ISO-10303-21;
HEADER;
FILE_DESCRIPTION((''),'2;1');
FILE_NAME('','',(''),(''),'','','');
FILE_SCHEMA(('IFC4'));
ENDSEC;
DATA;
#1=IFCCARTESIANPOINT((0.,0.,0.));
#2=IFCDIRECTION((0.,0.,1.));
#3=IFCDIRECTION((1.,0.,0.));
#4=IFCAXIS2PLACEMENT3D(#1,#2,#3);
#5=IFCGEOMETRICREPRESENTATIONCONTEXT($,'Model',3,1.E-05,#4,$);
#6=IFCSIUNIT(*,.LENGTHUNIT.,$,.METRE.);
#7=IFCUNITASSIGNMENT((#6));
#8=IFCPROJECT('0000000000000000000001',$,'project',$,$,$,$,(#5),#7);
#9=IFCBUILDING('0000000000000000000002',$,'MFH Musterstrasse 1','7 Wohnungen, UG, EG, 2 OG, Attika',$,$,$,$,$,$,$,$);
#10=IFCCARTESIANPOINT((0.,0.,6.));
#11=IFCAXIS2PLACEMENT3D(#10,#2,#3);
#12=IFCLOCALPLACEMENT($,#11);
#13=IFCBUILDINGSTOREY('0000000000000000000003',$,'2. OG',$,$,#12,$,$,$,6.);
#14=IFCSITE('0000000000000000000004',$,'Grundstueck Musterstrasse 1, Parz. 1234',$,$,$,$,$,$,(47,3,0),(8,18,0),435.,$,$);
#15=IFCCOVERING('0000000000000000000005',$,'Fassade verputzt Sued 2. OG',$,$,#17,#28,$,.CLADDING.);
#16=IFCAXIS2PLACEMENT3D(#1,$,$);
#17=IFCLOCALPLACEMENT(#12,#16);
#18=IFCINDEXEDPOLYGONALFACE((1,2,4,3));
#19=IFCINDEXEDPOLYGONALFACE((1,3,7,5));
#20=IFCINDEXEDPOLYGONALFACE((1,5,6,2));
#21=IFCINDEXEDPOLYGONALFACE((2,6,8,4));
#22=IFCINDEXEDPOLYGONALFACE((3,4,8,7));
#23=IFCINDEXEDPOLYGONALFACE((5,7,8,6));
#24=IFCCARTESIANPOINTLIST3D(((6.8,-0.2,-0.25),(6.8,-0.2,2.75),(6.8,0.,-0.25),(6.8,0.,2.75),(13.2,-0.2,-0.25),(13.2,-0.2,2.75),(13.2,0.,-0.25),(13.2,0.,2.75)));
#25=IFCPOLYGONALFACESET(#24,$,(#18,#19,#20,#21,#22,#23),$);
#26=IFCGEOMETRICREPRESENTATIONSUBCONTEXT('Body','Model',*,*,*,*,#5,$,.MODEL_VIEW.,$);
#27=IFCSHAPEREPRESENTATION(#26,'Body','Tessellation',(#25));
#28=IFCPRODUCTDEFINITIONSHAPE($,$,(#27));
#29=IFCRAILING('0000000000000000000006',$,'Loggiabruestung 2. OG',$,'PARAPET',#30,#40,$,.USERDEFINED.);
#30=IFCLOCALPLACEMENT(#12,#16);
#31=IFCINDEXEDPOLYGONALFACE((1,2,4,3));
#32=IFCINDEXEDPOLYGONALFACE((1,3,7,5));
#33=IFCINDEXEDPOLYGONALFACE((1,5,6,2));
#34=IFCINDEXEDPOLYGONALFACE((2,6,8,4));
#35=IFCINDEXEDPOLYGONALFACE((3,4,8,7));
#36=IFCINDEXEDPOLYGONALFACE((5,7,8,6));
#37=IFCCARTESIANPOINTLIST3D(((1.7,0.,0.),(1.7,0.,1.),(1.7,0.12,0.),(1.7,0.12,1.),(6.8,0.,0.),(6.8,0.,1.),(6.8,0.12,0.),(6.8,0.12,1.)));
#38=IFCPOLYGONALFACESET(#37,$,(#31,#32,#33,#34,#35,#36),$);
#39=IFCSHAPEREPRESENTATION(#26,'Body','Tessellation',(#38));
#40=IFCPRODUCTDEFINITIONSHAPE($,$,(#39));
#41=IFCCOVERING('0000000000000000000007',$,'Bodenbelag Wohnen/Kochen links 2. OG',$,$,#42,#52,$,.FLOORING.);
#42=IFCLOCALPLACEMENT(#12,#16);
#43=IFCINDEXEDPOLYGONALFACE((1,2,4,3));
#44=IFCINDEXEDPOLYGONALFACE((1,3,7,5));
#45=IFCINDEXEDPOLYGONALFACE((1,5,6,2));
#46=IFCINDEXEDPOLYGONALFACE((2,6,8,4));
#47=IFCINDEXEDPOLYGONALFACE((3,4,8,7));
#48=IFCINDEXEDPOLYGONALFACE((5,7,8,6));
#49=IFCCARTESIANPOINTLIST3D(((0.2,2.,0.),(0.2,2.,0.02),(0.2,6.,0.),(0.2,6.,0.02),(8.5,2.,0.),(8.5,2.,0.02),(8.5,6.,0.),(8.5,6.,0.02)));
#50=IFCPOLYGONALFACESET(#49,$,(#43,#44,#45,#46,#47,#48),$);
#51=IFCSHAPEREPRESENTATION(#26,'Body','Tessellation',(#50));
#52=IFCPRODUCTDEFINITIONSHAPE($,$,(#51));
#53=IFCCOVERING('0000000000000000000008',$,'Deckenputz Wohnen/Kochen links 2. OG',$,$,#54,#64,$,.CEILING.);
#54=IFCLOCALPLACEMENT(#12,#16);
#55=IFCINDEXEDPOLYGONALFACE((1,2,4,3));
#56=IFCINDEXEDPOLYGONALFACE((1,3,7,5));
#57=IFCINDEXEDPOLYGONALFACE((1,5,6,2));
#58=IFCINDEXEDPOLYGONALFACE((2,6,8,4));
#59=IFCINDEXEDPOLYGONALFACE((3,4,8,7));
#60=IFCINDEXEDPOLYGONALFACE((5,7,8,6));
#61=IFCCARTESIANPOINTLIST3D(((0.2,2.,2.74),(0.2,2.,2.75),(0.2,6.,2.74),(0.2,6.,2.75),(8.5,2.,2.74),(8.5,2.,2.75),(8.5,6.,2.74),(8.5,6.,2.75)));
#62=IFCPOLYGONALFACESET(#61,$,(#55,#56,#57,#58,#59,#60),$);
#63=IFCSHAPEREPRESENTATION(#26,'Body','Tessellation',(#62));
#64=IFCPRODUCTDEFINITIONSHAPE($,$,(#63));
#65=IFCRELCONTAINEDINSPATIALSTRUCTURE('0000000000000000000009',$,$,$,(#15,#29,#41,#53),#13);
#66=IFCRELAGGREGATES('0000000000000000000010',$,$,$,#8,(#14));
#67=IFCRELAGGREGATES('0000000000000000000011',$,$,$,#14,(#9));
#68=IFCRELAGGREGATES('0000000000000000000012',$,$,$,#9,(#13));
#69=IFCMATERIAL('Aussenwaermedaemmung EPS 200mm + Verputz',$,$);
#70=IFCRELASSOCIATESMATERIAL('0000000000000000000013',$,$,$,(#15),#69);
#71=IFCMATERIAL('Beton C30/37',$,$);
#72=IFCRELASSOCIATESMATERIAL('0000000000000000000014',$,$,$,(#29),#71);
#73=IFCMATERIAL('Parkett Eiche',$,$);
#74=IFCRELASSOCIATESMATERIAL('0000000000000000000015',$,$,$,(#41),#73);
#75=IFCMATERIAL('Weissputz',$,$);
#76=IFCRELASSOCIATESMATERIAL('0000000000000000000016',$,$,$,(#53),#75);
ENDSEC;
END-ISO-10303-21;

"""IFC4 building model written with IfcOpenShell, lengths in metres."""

from ifc_helpers import new_model, si_unit, frame, frame_2d, origin_with_axes, place, context, subcontext, project, spatial, rectangle, extrude, material, element, save


model = new_model("IFC4")

# Units and contexts
model_context = context("Model", 3, precision=1e-05, world=origin_with_axes())
body_context = subcontext(model_context, "Body", "Model", "MODEL_VIEW")
ifc_project = project(units=[si_unit("LENGTHUNIT", "METRE")], contexts=[model_context])

# Site, building, storey
site = spatial("IfcSite", under=ifc_project, Name="Grundstueck Musterstrasse 1, Parz. 1234", RefLatitude=(47, 3, 0), RefLongitude=(8, 18, 0), RefElevation=435.0)
building = spatial("IfcBuilding", under=site, Name="MFH Musterstrasse 1", Description="7 Wohnungen, UG, EG, 2 OG, Attika")
storey_placement = place(None, frame((0.0, 0.0, 6.0), z_axis=(0.0, 0.0, 1.0), x_axis=(1.0, 0.0, 0.0)))
storey = spatial("IfcBuildingStorey", under=building, at=storey_placement, Name="2. OG", Elevation=6.0)

# Shared definitions
ifc_material_1 = material(Name="Aussenwaermedaemmung EPS 200mm + Verputz")

# Covering
covering_1_placement = place(storey_placement, frame((7.0, -0.2, -0.25), z_axis=(0.0, 0.0, 1.0), x_axis=(1.0, 0.0, 0.0)))
element("IfcCovering", 1, at=covering_1_placement, inside=storey, material=ifc_material_1, Name="Fassade verputzt Sued 2. OG", PredefinedType="CLADDING", context=body_context, shape_type="SweptSolid", body=[
    extrude(rectangle(XDim=6.4, YDim=0.2, at=frame_2d((3.0, 0.1))), origin_with_axes(), (0.0, 0.0, 1.0), 3.0),
])

# Railing
ifc_material_2 = material(Name="Beton C30/37")
railing_placement = place(storey_placement, frame((1.7, 0.0, 0.0), z_axis=(0.0, 0.0, 1.0), x_axis=(1.0, 0.0, 0.0)))
element("IfcRailing", 2, at=railing_placement, inside=storey, material=ifc_material_2, Name="Loggiabruestung 2. OG", ObjectType="PARAPET", PredefinedType="USERDEFINED", context=body_context, shape_type="SweptSolid", body=[
    extrude(rectangle(XDim=5.1, YDim=0.12, at=frame_2d((2.55, 0.06))), origin_with_axes(), (0.0, 0.0, 1.0), 1.0),
])

# Coverings
ifc_material_3 = material(Name="Parkett Eiche")
covering_2_placement = place(storey_placement, frame((0.2, 2.0, 0.0), z_axis=(0.0, 0.0, 1.0), x_axis=(1.0, 0.0, 0.0)))
element("IfcCovering", 3, at=covering_2_placement, inside=storey, material=ifc_material_3, Name="Bodenbelag Wohnen/Kochen links 2. OG", PredefinedType="FLOORING", context=body_context, shape_type="SweptSolid", body=[
    extrude(rectangle(XDim=8.3, YDim=4.0, at=frame_2d((4.15, 2.0))), origin_with_axes(), (0.0, 0.0, 1.0), 0.02),
])
ifc_material_4 = material(Name="Weissputz")
covering_3_placement = place(storey_placement, frame((0.2, 2.0, 2.74), z_axis=(0.0, 0.0, 1.0), x_axis=(1.0, 0.0, 0.0)))
element("IfcCovering", 4, at=covering_3_placement, inside=storey, material=ifc_material_4, Name="Deckenputz Wohnen/Kochen links 2. OG", PredefinedType="CEILING", context=body_context, shape_type="SweptSolid", body=[
    extrude(rectangle(XDim=8.3, YDim=4.0, at=frame_2d((4.15, 2.0))), origin_with_axes(), (0.0, 0.0, 1.0), 0.01),
])

save(model, "model.ifc")
